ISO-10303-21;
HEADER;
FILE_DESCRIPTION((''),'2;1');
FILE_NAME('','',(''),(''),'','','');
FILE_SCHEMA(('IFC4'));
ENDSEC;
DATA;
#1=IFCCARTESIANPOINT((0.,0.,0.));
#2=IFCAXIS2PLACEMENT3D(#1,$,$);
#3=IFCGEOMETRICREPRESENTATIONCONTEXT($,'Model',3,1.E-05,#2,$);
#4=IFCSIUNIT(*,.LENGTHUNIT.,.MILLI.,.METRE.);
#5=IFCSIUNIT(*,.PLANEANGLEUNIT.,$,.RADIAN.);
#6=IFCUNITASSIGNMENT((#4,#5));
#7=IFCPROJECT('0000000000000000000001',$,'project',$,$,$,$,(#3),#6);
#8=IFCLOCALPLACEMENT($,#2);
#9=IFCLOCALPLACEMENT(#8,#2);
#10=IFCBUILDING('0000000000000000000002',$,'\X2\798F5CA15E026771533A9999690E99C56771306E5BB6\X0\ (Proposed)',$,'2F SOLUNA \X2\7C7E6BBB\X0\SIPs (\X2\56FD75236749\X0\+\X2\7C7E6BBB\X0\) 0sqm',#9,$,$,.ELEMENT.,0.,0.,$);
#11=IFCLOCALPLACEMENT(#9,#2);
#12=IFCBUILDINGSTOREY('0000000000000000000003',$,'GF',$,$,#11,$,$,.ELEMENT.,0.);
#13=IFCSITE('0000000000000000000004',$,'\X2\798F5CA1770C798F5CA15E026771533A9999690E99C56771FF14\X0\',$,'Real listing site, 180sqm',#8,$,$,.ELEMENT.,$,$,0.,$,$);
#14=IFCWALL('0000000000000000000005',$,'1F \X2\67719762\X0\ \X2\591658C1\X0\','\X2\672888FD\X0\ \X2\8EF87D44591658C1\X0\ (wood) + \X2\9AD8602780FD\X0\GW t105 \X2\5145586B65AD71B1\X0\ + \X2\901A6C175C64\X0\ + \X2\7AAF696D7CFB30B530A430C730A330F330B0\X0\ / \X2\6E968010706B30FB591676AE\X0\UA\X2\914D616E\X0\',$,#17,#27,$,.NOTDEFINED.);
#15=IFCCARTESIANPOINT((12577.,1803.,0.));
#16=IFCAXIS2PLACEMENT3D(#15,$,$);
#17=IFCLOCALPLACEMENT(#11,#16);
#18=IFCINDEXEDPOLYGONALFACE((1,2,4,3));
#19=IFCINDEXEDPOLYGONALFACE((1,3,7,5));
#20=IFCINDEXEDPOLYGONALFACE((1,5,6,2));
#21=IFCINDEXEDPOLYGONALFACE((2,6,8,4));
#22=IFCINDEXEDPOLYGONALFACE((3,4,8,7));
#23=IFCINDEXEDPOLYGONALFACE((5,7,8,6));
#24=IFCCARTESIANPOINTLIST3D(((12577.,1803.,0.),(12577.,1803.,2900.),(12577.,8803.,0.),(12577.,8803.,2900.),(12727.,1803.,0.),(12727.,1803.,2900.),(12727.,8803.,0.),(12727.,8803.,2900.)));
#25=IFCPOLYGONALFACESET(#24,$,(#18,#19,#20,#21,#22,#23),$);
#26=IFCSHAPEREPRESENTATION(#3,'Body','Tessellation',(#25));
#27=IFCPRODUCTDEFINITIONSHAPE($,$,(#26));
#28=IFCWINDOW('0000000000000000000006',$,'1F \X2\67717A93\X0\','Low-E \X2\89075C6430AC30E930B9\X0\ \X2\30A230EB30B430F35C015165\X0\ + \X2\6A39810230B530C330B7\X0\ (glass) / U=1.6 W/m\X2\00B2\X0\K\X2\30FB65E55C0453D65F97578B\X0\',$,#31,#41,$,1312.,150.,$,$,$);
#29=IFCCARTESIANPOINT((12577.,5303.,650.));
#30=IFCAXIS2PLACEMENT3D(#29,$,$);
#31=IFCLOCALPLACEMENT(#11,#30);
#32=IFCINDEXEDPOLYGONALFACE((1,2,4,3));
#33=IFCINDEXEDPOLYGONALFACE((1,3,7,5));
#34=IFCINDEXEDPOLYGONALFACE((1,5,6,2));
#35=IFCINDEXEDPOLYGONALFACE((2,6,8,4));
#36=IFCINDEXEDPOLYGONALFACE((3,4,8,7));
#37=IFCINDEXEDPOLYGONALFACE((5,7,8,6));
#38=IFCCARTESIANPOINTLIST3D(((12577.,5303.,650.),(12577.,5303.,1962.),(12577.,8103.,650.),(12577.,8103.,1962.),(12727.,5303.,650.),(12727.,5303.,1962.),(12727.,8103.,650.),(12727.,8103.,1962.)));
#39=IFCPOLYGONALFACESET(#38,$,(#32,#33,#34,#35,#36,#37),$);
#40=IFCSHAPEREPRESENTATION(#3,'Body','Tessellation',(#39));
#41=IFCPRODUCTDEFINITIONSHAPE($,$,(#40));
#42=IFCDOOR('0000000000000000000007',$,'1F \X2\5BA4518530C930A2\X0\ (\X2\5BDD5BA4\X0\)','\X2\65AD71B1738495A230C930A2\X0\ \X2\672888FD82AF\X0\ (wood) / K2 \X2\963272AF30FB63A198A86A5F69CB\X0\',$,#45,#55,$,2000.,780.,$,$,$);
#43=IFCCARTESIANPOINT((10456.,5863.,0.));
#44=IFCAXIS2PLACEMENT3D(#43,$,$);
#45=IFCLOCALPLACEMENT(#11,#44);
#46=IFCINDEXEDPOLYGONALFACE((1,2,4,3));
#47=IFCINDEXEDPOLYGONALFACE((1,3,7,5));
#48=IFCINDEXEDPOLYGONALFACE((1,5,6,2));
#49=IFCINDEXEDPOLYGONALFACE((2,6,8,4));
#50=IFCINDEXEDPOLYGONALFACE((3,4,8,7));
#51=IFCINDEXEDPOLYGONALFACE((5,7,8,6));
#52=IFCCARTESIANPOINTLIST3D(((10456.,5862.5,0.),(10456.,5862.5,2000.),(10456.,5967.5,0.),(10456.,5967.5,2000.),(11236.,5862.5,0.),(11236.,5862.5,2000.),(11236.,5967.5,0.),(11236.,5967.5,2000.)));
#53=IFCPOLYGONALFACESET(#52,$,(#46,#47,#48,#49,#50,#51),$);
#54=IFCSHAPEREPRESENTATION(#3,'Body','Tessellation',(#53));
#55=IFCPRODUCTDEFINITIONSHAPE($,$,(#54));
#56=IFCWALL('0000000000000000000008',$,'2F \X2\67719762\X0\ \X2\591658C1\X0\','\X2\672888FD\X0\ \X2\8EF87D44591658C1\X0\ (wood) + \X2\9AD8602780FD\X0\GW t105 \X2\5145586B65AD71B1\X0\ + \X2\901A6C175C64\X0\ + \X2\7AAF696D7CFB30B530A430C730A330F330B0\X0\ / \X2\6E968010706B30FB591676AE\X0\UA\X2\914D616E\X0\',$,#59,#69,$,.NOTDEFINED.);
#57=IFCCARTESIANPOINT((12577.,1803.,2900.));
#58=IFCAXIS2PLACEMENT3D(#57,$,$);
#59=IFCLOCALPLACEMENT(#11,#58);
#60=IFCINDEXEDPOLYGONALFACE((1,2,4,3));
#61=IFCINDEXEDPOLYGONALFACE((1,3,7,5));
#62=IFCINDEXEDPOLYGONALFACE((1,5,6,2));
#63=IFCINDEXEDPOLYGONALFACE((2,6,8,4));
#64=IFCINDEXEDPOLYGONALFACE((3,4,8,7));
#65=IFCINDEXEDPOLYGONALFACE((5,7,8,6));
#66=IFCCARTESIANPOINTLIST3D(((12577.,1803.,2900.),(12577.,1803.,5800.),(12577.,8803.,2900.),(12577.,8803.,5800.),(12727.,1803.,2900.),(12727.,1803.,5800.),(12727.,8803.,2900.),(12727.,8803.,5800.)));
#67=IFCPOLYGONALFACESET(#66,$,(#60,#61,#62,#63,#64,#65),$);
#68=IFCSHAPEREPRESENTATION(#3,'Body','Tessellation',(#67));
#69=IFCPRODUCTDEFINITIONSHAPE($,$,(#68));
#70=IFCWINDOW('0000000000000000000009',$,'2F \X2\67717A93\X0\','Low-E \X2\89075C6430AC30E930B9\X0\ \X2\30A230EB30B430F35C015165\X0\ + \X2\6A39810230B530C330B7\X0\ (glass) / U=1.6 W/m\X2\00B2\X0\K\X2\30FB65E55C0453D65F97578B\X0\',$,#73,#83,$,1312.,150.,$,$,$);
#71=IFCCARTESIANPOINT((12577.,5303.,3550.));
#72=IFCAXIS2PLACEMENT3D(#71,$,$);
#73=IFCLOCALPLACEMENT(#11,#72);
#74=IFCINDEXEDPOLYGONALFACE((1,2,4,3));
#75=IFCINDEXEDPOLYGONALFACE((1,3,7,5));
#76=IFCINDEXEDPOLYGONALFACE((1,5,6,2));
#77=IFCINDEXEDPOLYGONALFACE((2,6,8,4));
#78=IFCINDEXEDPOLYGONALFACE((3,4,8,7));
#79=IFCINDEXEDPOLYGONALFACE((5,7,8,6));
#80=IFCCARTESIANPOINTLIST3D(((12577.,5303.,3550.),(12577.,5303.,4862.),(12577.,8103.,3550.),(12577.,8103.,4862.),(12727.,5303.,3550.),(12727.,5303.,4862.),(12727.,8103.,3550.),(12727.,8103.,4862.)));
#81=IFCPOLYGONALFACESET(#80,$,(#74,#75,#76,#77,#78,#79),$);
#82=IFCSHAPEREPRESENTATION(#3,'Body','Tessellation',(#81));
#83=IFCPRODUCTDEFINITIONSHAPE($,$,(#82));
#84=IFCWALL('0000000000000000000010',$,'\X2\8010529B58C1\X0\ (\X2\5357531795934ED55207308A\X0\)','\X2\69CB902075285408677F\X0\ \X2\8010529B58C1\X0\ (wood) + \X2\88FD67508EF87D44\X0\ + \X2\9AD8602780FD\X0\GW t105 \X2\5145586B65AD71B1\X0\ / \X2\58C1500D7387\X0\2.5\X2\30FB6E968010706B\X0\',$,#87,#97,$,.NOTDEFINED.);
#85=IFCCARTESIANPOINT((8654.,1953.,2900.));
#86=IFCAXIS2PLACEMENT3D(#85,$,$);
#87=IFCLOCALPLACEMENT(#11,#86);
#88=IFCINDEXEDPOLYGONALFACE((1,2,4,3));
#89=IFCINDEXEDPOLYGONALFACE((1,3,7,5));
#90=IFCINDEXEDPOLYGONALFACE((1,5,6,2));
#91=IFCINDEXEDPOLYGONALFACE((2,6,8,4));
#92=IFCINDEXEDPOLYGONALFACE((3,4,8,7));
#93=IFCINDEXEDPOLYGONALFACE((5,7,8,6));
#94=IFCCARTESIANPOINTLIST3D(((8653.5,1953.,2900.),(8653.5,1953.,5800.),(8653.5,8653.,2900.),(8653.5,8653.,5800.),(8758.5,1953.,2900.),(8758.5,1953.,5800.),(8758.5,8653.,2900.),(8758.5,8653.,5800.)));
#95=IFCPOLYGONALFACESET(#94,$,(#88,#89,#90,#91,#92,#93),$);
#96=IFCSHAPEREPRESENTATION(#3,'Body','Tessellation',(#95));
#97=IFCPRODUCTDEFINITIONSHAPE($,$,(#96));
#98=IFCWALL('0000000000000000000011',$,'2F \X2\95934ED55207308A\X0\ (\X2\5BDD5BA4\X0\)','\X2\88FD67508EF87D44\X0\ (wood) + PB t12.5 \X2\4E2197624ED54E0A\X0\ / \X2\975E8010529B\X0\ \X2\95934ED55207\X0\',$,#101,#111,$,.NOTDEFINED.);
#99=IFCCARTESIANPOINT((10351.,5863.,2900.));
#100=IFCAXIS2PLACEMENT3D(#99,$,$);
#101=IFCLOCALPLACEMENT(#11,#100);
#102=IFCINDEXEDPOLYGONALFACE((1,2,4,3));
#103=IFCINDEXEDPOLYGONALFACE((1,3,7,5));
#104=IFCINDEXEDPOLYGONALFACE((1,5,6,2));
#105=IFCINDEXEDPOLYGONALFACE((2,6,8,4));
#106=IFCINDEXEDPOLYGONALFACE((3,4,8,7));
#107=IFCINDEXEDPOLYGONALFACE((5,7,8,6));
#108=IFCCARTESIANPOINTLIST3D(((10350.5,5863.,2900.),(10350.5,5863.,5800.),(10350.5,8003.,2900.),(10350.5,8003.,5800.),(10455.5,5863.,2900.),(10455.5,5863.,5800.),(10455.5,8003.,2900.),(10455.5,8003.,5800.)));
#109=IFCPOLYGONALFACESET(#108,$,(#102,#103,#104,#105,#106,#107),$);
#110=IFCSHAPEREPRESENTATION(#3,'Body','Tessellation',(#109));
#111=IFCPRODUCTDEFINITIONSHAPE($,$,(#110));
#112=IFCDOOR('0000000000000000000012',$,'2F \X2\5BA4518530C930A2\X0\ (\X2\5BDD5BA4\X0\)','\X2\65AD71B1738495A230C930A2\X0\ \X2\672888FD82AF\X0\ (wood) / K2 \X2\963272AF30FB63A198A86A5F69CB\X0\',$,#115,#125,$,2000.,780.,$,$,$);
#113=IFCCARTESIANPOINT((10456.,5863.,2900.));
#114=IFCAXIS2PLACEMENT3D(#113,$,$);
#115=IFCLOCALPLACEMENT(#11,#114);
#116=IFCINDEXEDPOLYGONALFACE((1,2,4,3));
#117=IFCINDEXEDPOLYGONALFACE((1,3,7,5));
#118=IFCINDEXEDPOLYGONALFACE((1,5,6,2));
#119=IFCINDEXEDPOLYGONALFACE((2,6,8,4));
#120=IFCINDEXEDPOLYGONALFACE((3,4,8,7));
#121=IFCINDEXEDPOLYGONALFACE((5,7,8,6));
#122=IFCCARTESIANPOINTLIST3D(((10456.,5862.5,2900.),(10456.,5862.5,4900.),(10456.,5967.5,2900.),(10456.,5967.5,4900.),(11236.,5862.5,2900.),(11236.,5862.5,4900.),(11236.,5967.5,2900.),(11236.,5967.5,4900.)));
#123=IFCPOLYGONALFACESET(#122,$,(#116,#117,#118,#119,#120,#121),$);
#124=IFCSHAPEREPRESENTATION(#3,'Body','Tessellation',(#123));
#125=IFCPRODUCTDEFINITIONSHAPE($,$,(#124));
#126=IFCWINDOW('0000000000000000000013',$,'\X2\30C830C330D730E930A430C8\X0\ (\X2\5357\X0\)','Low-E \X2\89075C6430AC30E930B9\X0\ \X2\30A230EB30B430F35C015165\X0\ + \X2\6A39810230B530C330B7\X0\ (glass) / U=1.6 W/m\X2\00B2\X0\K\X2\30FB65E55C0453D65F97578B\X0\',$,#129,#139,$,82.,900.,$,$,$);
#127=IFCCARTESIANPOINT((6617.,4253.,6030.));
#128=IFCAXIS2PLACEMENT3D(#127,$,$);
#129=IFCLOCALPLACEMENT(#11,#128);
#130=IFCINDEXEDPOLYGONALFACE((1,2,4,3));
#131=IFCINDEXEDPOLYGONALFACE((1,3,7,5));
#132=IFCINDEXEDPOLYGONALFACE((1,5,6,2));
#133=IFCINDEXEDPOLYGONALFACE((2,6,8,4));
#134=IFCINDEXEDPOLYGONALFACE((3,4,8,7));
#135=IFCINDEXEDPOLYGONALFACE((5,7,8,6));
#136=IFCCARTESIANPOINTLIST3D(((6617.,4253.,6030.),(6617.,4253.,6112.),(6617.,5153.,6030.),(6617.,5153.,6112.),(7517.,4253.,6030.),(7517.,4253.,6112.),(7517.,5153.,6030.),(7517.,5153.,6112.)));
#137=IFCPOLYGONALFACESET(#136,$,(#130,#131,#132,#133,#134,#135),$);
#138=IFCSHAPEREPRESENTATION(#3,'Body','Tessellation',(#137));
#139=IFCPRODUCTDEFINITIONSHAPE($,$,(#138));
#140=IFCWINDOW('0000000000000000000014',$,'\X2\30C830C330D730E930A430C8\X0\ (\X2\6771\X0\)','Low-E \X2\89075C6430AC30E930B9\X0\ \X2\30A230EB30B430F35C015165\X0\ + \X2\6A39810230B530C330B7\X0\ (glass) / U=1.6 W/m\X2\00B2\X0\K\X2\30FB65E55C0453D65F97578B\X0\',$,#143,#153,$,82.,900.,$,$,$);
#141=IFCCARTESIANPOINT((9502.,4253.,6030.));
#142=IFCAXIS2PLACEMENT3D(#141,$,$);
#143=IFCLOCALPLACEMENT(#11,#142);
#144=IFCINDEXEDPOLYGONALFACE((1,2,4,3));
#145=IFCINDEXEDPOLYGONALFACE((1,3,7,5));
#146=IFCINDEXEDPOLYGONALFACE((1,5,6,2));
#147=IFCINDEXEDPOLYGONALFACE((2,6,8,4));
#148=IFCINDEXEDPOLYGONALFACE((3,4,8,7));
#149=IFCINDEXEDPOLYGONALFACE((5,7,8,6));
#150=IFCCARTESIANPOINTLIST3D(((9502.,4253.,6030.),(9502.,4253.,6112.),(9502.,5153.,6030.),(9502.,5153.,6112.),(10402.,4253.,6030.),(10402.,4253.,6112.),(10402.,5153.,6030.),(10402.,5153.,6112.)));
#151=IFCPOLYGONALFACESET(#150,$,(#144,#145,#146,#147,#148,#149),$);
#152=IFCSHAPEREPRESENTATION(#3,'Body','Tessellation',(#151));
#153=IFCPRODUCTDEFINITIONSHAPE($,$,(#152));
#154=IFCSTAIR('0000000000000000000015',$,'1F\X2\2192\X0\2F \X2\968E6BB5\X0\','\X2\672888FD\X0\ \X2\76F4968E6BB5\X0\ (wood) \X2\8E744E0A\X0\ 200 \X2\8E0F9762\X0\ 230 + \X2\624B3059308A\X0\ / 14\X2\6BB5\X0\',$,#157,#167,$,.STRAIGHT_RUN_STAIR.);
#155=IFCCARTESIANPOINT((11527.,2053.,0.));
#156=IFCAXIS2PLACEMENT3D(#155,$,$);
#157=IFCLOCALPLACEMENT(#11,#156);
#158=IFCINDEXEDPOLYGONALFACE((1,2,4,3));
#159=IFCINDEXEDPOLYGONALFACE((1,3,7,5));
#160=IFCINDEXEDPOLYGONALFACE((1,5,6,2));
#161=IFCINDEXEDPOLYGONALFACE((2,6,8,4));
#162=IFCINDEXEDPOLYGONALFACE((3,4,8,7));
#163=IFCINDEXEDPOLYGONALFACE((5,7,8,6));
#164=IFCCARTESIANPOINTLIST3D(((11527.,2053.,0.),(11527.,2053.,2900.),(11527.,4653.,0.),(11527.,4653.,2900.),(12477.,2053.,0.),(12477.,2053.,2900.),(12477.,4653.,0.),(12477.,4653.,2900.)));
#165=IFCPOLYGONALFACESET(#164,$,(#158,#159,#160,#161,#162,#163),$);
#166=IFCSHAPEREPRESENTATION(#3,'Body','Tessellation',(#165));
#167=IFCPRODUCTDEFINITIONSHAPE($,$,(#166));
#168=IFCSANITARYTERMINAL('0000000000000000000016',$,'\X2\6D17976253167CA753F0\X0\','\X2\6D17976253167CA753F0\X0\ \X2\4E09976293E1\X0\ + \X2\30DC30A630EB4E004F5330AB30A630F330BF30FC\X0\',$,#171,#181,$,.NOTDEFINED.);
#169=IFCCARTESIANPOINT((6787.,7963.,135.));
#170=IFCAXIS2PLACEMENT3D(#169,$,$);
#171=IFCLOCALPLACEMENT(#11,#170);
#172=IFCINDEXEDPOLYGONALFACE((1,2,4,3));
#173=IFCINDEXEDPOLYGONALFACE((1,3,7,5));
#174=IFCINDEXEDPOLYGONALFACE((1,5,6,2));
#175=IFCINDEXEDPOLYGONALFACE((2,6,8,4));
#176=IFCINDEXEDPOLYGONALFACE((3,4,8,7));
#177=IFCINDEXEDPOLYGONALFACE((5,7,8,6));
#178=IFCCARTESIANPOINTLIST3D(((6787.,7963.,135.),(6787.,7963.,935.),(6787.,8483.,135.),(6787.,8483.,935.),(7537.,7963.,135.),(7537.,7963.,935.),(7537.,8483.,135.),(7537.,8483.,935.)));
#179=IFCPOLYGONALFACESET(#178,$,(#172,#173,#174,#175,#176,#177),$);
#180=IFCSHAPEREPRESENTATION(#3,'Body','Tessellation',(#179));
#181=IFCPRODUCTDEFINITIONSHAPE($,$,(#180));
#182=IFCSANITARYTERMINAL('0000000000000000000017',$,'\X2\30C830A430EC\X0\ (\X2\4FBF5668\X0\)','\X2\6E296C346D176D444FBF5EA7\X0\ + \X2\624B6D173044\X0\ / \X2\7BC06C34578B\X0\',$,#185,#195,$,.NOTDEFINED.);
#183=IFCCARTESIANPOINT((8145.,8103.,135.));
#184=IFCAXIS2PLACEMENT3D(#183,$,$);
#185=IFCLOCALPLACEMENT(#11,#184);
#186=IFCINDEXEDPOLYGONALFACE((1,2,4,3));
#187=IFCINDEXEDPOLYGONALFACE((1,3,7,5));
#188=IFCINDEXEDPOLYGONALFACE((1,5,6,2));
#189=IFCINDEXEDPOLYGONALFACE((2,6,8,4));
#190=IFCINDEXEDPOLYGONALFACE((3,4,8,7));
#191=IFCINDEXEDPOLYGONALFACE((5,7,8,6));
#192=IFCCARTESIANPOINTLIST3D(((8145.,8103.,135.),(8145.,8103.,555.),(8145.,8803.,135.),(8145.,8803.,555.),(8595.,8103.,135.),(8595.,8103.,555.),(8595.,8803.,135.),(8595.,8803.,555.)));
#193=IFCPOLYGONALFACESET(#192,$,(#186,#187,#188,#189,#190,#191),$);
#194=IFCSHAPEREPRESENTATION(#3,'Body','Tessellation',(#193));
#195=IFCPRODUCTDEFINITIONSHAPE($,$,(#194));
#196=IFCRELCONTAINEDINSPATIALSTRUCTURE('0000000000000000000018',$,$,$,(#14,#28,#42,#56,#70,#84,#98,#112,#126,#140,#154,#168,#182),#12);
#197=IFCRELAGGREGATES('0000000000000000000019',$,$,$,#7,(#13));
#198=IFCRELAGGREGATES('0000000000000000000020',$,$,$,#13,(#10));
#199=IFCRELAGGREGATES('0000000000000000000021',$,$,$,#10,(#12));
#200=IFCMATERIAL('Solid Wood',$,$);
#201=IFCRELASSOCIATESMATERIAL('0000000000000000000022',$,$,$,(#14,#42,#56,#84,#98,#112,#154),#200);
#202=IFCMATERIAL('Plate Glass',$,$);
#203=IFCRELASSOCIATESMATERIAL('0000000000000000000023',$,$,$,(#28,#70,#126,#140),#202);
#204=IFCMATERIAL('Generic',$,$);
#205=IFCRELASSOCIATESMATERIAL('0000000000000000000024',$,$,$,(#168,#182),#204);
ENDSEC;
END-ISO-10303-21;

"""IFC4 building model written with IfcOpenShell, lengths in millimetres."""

from ifc_helpers import new_model, si_unit, frame, frame_2d, origin, place, context, project, spatial, rectangle, extrude, material, element, fill, save


model = new_model("IFC4")

# Units and contexts
model_context = context("Model", 3, precision=1e-05, world=origin())
ifc_project = project(units=[si_unit("LENGTHUNIT", "METRE", prefix="MILLI"), si_unit("PLANEANGLEUNIT", "RADIAN")], contexts=[model_context])

# Site, building, storey
site_placement = place(None, origin())
site = spatial("IfcSite", under=ifc_project, at=site_placement, Name="福岡県福岡市東区香椎駅東４", ObjectType="Real listing site, 180sqm", CompositionType="ELEMENT", RefElevation=0.0)
building_placement = place(site_placement, origin())
building = spatial("IfcBuilding", under=site, at=building_placement, Name="福岡市東区香椎駅東の家 (Proposed)", ObjectType="2F SOLUNA 籾殻SIPs (国産杉+籾殻) 0sqm", CompositionType="ELEMENT", ElevationOfRefHeight=0.0, ElevationOfTerrain=0.0)
storey_placement = place(building_placement, origin())
storey = spatial("IfcBuildingStorey", under=building, at=storey_placement, Name="GF", CompositionType="ELEMENT", Elevation=0.0)

# Wall, opening, window
ifc_material_1 = material(Name="Solid Wood")
wall_1_placement = place(storey_placement, frame((12577.0, 1803.0, 0.0)))
wall_1 = element("IfcWall", 1, at=wall_1_placement, inside=storey, material=ifc_material_1, Name="1F 東面 外壁", Description="木製 軸組外壁 (wood) + 高性能GW t105 充填断熱 + 通気層 + 窯業系サイディング / 準耐火・外皮UA配慮", PredefinedType="NOTDEFINED", context=model_context, shape_type="SweptSolid", body=[
    extrude(rectangle(XDim=150.0, YDim=7000.0, at=frame_2d((75.0, 3500.0))), frame((12577.0, 1803.0, 0.0)), (0.0, 0.0, 1.0), 2900.0),
])
opening_1_placement = place(storey_placement, frame((12577.0, 5303.0, 650.0)))
opening_1 = element("IfcOpeningElement", 2, at=opening_1_placement, cuts=wall_1, PredefinedType="NOTDEFINED", context=model_context, shape_type="SweptSolid", body=[
    extrude(rectangle(XDim=150.0, YDim=2800.0, at=frame_2d((75.0, 1400.0))), frame((12577.0, 5303.0, 650.0)), (0.0, 0.0, 1.0), 1312.0),
])
ifc_material_2 = material(Name="Plate Glass")
window_1_placement = place(storey_placement, frame((12577.0, 5303.0, 650.0)))
window_1 = element("IfcWindow", 3, at=window_1_placement, inside=storey, material=ifc_material_2, Name="1F 東窓", Description="Low-E 複層ガラス アルゴン封入 + 樹脂サッシ (glass) / U=1.6 W/m²K・日射取得型", OverallHeight=1312.0, OverallWidth=150.0, context=model_context, shape_type="SweptSolid", body=[
    extrude(rectangle(XDim=150.0, YDim=2800.0, at=frame_2d((75.0, 1400.0))), frame((12577.0, 5303.0, 650.0)), (0.0, 0.0, 1.0), 1312.0),
])
fill(opening_1, window_1)

# Door
door_1_placement = place(storey_placement, frame((10456.0, 5863.0, 0.0)))
element("IfcDoor", 4, at=door_1_placement, inside=storey, material=ifc_material_1, Name="1F 室内ドア (寝室)", Description="断熱玄関ドア 木製芯 (wood) / K2 防犯・採風機構", OverallHeight=2000.0, OverallWidth=780.0, context=model_context, shape_type="SweptSolid", body=[
    extrude(rectangle(XDim=780.0, YDim=105.0, at=frame_2d((390.0, 52.0))), frame((10456.0, 5863.0, 0.0)), (0.0, 0.0, 1.0), 2000.0),
])

# Wall, opening, window
wall_2_placement = place(storey_placement, frame((12577.0, 1803.0, 2900.0)))
wall_2 = element("IfcWall", 5, at=wall_2_placement, inside=storey, material=ifc_material_1, Name="2F 東面 外壁", Description="木製 軸組外壁 (wood) + 高性能GW t105 充填断熱 + 通気層 + 窯業系サイディング / 準耐火・外皮UA配慮", PredefinedType="NOTDEFINED", context=model_context, shape_type="SweptSolid", body=[
    extrude(rectangle(XDim=150.0, YDim=7000.0, at=frame_2d((75.0, 3500.0))), frame((12577.0, 1803.0, 2900.0)), (0.0, 0.0, 1.0), 2900.0),
])
opening_2_placement = place(storey_placement, frame((12577.0, 5303.0, 3550.0)))
opening_2 = element("IfcOpeningElement", 6, at=opening_2_placement, cuts=wall_2, PredefinedType="NOTDEFINED", context=model_context, shape_type="SweptSolid", body=[
    extrude(rectangle(XDim=150.0, YDim=2800.0, at=frame_2d((75.0, 1400.0))), frame((12577.0, 5303.0, 3550.0)), (0.0, 0.0, 1.0), 1312.0),
])
window_2_placement = place(storey_placement, frame((12577.0, 5303.0, 3550.0)))
window_2 = element("IfcWindow", 7, at=window_2_placement, inside=storey, material=ifc_material_2, Name="2F 東窓", Description="Low-E 複層ガラス アルゴン封入 + 樹脂サッシ (glass) / U=1.6 W/m²K・日射取得型", OverallHeight=1312.0, OverallWidth=150.0, context=model_context, shape_type="SweptSolid", body=[
    extrude(rectangle(XDim=150.0, YDim=2800.0, at=frame_2d((75.0, 1400.0))), frame((12577.0, 5303.0, 3550.0)), (0.0, 0.0, 1.0), 1312.0),
])
fill(opening_2, window_2)

# Walls
wall_3_placement = place(storey_placement, frame((8654.0, 1953.0, 2900.0)))
element("IfcWall", 8, at=wall_3_placement, inside=storey, material=ifc_material_1, Name="耐力壁 (南北間仕切り)", Description="構造用合板 耐力壁 (wood) + 製材軸組 + 高性能GW t105 充填断熱 / 壁倍率2.5・準耐火", PredefinedType="NOTDEFINED", context=model_context, shape_type="SweptSolid", body=[
    extrude(rectangle(XDim=105.0, YDim=6700.0, at=frame_2d((52.0, 3350.0))), frame((8654.0, 1953.0, 2900.0)), (0.0, 0.0, 1.0), 2900.0),
])
wall_4_placement = place(storey_placement, frame((10351.0, 5863.0, 2900.0)))
element("IfcWall", 9, at=wall_4_placement, inside=storey, material=ifc_material_1, Name="2F 間仕切り (寝室)", Description="製材軸組 (wood) + PB t12.5 両面仕上 / 非耐力 間仕切", PredefinedType="NOTDEFINED", context=model_context, shape_type="SweptSolid", body=[
    extrude(rectangle(XDim=105.0, YDim=2140.0, at=frame_2d((52.0, 1070.0))), frame((10351.0, 5863.0, 2900.0)), (0.0, 0.0, 1.0), 2900.0),
])

# Door
door_2_placement = place(storey_placement, frame((10456.0, 5863.0, 2900.0)))
element("IfcDoor", 10, at=door_2_placement, inside=storey, material=ifc_material_1, Name="2F 室内ドア (寝室)", Description="断熱玄関ドア 木製芯 (wood) / K2 防犯・採風機構", OverallHeight=2000.0, OverallWidth=780.0, context=model_context, shape_type="SweptSolid", body=[
    extrude(rectangle(XDim=780.0, YDim=105.0, at=frame_2d((390.0, 52.0))), frame((10456.0, 5863.0, 2900.0)), (0.0, 0.0, 1.0), 2000.0),
])

# Windows
window_3_placement = place(storey_placement, frame((6617.0, 4253.0, 6030.0)))
element("IfcWindow", 11, at=window_3_placement, inside=storey, material=ifc_material_2, Name="トップライト (南)", Description="Low-E 複層ガラス アルゴン封入 + 樹脂サッシ (glass) / U=1.6 W/m²K・日射取得型", OverallHeight=82.0, OverallWidth=900.0, context=model_context, shape_type="SweptSolid", body=[
    extrude(rectangle(XDim=900.0, YDim=900.0, at=frame_2d((450.0, 450.0))), frame((6617.0, 4253.0, 6030.0)), (0.0, 0.0, 1.0), 82.0),
])
window_4_placement = place(storey_placement, frame((9502.0, 4253.0, 6030.0)))
element("IfcWindow", 12, at=window_4_placement, inside=storey, material=ifc_material_2, Name="トップライト (東)", Description="Low-E 複層ガラス アルゴン封入 + 樹脂サッシ (glass) / U=1.6 W/m²K・日射取得型", OverallHeight=82.0, OverallWidth=900.0, context=model_context, shape_type="SweptSolid", body=[
    extrude(rectangle(XDim=900.0, YDim=900.0, at=frame_2d((450.0, 450.0))), frame((9502.0, 4253.0, 6030.0)), (0.0, 0.0, 1.0), 82.0),
])

# Stair
stair_placement = place(storey_placement, frame((11527.0, 2053.0, 0.0)))
element("IfcStair", 13, at=stair_placement, inside=storey, material=ifc_material_1, Name="1F→2F 階段", Description="木製 直階段 (wood) 蹴上 200 踏面 230 + 手すり / 14段", PredefinedType="STRAIGHT_RUN_STAIR", context=model_context, shape_type="SweptSolid", body=[
    extrude(rectangle(XDim=950.0, YDim=2600.0, at=frame_2d((475.0, 1300.0))), frame((11527.0, 2053.0, 0.0)), (0.0, 0.0, 1.0), 2900.0),
])

# Sanitary terminals
ifc_material_3 = material(Name="Generic")
sanitary_terminal_1_placement = place(storey_placement, frame((6787.0, 7963.0, 135.0)))
element("IfcSanitaryTerminal", 14, at=sanitary_terminal_1_placement, inside=storey, material=ifc_material_3, Name="洗面化粧台", Description="洗面化粧台 三面鏡 + ボウル一体カウンター", PredefinedType="NOTDEFINED", context=model_context, shape_type="SweptSolid", body=[
    extrude(rectangle(XDim=750.0, YDim=520.0, at=frame_2d((375.0, 260.0))), frame((6787.0, 7963.0, 135.0)), (0.0, 0.0, 1.0), 800.0),
])
sanitary_terminal_2_placement = place(storey_placement, frame((8145.0, 8103.0, 135.0)))
element("IfcSanitaryTerminal", 15, at=sanitary_terminal_2_placement, inside=storey, material=ifc_material_3, Name="トイレ (便器)", Description="温水洗浄便座 + 手洗い / 節水型", PredefinedType="NOTDEFINED", context=model_context, shape_type="SweptSolid", body=[
    extrude(rectangle(XDim=450.0, YDim=700.0, at=frame_2d((225.0, 350.0))), frame((8145.0, 8103.0, 135.0)), (0.0, 0.0, 1.0), 420.0),
])

save(model, "model.ifc")
